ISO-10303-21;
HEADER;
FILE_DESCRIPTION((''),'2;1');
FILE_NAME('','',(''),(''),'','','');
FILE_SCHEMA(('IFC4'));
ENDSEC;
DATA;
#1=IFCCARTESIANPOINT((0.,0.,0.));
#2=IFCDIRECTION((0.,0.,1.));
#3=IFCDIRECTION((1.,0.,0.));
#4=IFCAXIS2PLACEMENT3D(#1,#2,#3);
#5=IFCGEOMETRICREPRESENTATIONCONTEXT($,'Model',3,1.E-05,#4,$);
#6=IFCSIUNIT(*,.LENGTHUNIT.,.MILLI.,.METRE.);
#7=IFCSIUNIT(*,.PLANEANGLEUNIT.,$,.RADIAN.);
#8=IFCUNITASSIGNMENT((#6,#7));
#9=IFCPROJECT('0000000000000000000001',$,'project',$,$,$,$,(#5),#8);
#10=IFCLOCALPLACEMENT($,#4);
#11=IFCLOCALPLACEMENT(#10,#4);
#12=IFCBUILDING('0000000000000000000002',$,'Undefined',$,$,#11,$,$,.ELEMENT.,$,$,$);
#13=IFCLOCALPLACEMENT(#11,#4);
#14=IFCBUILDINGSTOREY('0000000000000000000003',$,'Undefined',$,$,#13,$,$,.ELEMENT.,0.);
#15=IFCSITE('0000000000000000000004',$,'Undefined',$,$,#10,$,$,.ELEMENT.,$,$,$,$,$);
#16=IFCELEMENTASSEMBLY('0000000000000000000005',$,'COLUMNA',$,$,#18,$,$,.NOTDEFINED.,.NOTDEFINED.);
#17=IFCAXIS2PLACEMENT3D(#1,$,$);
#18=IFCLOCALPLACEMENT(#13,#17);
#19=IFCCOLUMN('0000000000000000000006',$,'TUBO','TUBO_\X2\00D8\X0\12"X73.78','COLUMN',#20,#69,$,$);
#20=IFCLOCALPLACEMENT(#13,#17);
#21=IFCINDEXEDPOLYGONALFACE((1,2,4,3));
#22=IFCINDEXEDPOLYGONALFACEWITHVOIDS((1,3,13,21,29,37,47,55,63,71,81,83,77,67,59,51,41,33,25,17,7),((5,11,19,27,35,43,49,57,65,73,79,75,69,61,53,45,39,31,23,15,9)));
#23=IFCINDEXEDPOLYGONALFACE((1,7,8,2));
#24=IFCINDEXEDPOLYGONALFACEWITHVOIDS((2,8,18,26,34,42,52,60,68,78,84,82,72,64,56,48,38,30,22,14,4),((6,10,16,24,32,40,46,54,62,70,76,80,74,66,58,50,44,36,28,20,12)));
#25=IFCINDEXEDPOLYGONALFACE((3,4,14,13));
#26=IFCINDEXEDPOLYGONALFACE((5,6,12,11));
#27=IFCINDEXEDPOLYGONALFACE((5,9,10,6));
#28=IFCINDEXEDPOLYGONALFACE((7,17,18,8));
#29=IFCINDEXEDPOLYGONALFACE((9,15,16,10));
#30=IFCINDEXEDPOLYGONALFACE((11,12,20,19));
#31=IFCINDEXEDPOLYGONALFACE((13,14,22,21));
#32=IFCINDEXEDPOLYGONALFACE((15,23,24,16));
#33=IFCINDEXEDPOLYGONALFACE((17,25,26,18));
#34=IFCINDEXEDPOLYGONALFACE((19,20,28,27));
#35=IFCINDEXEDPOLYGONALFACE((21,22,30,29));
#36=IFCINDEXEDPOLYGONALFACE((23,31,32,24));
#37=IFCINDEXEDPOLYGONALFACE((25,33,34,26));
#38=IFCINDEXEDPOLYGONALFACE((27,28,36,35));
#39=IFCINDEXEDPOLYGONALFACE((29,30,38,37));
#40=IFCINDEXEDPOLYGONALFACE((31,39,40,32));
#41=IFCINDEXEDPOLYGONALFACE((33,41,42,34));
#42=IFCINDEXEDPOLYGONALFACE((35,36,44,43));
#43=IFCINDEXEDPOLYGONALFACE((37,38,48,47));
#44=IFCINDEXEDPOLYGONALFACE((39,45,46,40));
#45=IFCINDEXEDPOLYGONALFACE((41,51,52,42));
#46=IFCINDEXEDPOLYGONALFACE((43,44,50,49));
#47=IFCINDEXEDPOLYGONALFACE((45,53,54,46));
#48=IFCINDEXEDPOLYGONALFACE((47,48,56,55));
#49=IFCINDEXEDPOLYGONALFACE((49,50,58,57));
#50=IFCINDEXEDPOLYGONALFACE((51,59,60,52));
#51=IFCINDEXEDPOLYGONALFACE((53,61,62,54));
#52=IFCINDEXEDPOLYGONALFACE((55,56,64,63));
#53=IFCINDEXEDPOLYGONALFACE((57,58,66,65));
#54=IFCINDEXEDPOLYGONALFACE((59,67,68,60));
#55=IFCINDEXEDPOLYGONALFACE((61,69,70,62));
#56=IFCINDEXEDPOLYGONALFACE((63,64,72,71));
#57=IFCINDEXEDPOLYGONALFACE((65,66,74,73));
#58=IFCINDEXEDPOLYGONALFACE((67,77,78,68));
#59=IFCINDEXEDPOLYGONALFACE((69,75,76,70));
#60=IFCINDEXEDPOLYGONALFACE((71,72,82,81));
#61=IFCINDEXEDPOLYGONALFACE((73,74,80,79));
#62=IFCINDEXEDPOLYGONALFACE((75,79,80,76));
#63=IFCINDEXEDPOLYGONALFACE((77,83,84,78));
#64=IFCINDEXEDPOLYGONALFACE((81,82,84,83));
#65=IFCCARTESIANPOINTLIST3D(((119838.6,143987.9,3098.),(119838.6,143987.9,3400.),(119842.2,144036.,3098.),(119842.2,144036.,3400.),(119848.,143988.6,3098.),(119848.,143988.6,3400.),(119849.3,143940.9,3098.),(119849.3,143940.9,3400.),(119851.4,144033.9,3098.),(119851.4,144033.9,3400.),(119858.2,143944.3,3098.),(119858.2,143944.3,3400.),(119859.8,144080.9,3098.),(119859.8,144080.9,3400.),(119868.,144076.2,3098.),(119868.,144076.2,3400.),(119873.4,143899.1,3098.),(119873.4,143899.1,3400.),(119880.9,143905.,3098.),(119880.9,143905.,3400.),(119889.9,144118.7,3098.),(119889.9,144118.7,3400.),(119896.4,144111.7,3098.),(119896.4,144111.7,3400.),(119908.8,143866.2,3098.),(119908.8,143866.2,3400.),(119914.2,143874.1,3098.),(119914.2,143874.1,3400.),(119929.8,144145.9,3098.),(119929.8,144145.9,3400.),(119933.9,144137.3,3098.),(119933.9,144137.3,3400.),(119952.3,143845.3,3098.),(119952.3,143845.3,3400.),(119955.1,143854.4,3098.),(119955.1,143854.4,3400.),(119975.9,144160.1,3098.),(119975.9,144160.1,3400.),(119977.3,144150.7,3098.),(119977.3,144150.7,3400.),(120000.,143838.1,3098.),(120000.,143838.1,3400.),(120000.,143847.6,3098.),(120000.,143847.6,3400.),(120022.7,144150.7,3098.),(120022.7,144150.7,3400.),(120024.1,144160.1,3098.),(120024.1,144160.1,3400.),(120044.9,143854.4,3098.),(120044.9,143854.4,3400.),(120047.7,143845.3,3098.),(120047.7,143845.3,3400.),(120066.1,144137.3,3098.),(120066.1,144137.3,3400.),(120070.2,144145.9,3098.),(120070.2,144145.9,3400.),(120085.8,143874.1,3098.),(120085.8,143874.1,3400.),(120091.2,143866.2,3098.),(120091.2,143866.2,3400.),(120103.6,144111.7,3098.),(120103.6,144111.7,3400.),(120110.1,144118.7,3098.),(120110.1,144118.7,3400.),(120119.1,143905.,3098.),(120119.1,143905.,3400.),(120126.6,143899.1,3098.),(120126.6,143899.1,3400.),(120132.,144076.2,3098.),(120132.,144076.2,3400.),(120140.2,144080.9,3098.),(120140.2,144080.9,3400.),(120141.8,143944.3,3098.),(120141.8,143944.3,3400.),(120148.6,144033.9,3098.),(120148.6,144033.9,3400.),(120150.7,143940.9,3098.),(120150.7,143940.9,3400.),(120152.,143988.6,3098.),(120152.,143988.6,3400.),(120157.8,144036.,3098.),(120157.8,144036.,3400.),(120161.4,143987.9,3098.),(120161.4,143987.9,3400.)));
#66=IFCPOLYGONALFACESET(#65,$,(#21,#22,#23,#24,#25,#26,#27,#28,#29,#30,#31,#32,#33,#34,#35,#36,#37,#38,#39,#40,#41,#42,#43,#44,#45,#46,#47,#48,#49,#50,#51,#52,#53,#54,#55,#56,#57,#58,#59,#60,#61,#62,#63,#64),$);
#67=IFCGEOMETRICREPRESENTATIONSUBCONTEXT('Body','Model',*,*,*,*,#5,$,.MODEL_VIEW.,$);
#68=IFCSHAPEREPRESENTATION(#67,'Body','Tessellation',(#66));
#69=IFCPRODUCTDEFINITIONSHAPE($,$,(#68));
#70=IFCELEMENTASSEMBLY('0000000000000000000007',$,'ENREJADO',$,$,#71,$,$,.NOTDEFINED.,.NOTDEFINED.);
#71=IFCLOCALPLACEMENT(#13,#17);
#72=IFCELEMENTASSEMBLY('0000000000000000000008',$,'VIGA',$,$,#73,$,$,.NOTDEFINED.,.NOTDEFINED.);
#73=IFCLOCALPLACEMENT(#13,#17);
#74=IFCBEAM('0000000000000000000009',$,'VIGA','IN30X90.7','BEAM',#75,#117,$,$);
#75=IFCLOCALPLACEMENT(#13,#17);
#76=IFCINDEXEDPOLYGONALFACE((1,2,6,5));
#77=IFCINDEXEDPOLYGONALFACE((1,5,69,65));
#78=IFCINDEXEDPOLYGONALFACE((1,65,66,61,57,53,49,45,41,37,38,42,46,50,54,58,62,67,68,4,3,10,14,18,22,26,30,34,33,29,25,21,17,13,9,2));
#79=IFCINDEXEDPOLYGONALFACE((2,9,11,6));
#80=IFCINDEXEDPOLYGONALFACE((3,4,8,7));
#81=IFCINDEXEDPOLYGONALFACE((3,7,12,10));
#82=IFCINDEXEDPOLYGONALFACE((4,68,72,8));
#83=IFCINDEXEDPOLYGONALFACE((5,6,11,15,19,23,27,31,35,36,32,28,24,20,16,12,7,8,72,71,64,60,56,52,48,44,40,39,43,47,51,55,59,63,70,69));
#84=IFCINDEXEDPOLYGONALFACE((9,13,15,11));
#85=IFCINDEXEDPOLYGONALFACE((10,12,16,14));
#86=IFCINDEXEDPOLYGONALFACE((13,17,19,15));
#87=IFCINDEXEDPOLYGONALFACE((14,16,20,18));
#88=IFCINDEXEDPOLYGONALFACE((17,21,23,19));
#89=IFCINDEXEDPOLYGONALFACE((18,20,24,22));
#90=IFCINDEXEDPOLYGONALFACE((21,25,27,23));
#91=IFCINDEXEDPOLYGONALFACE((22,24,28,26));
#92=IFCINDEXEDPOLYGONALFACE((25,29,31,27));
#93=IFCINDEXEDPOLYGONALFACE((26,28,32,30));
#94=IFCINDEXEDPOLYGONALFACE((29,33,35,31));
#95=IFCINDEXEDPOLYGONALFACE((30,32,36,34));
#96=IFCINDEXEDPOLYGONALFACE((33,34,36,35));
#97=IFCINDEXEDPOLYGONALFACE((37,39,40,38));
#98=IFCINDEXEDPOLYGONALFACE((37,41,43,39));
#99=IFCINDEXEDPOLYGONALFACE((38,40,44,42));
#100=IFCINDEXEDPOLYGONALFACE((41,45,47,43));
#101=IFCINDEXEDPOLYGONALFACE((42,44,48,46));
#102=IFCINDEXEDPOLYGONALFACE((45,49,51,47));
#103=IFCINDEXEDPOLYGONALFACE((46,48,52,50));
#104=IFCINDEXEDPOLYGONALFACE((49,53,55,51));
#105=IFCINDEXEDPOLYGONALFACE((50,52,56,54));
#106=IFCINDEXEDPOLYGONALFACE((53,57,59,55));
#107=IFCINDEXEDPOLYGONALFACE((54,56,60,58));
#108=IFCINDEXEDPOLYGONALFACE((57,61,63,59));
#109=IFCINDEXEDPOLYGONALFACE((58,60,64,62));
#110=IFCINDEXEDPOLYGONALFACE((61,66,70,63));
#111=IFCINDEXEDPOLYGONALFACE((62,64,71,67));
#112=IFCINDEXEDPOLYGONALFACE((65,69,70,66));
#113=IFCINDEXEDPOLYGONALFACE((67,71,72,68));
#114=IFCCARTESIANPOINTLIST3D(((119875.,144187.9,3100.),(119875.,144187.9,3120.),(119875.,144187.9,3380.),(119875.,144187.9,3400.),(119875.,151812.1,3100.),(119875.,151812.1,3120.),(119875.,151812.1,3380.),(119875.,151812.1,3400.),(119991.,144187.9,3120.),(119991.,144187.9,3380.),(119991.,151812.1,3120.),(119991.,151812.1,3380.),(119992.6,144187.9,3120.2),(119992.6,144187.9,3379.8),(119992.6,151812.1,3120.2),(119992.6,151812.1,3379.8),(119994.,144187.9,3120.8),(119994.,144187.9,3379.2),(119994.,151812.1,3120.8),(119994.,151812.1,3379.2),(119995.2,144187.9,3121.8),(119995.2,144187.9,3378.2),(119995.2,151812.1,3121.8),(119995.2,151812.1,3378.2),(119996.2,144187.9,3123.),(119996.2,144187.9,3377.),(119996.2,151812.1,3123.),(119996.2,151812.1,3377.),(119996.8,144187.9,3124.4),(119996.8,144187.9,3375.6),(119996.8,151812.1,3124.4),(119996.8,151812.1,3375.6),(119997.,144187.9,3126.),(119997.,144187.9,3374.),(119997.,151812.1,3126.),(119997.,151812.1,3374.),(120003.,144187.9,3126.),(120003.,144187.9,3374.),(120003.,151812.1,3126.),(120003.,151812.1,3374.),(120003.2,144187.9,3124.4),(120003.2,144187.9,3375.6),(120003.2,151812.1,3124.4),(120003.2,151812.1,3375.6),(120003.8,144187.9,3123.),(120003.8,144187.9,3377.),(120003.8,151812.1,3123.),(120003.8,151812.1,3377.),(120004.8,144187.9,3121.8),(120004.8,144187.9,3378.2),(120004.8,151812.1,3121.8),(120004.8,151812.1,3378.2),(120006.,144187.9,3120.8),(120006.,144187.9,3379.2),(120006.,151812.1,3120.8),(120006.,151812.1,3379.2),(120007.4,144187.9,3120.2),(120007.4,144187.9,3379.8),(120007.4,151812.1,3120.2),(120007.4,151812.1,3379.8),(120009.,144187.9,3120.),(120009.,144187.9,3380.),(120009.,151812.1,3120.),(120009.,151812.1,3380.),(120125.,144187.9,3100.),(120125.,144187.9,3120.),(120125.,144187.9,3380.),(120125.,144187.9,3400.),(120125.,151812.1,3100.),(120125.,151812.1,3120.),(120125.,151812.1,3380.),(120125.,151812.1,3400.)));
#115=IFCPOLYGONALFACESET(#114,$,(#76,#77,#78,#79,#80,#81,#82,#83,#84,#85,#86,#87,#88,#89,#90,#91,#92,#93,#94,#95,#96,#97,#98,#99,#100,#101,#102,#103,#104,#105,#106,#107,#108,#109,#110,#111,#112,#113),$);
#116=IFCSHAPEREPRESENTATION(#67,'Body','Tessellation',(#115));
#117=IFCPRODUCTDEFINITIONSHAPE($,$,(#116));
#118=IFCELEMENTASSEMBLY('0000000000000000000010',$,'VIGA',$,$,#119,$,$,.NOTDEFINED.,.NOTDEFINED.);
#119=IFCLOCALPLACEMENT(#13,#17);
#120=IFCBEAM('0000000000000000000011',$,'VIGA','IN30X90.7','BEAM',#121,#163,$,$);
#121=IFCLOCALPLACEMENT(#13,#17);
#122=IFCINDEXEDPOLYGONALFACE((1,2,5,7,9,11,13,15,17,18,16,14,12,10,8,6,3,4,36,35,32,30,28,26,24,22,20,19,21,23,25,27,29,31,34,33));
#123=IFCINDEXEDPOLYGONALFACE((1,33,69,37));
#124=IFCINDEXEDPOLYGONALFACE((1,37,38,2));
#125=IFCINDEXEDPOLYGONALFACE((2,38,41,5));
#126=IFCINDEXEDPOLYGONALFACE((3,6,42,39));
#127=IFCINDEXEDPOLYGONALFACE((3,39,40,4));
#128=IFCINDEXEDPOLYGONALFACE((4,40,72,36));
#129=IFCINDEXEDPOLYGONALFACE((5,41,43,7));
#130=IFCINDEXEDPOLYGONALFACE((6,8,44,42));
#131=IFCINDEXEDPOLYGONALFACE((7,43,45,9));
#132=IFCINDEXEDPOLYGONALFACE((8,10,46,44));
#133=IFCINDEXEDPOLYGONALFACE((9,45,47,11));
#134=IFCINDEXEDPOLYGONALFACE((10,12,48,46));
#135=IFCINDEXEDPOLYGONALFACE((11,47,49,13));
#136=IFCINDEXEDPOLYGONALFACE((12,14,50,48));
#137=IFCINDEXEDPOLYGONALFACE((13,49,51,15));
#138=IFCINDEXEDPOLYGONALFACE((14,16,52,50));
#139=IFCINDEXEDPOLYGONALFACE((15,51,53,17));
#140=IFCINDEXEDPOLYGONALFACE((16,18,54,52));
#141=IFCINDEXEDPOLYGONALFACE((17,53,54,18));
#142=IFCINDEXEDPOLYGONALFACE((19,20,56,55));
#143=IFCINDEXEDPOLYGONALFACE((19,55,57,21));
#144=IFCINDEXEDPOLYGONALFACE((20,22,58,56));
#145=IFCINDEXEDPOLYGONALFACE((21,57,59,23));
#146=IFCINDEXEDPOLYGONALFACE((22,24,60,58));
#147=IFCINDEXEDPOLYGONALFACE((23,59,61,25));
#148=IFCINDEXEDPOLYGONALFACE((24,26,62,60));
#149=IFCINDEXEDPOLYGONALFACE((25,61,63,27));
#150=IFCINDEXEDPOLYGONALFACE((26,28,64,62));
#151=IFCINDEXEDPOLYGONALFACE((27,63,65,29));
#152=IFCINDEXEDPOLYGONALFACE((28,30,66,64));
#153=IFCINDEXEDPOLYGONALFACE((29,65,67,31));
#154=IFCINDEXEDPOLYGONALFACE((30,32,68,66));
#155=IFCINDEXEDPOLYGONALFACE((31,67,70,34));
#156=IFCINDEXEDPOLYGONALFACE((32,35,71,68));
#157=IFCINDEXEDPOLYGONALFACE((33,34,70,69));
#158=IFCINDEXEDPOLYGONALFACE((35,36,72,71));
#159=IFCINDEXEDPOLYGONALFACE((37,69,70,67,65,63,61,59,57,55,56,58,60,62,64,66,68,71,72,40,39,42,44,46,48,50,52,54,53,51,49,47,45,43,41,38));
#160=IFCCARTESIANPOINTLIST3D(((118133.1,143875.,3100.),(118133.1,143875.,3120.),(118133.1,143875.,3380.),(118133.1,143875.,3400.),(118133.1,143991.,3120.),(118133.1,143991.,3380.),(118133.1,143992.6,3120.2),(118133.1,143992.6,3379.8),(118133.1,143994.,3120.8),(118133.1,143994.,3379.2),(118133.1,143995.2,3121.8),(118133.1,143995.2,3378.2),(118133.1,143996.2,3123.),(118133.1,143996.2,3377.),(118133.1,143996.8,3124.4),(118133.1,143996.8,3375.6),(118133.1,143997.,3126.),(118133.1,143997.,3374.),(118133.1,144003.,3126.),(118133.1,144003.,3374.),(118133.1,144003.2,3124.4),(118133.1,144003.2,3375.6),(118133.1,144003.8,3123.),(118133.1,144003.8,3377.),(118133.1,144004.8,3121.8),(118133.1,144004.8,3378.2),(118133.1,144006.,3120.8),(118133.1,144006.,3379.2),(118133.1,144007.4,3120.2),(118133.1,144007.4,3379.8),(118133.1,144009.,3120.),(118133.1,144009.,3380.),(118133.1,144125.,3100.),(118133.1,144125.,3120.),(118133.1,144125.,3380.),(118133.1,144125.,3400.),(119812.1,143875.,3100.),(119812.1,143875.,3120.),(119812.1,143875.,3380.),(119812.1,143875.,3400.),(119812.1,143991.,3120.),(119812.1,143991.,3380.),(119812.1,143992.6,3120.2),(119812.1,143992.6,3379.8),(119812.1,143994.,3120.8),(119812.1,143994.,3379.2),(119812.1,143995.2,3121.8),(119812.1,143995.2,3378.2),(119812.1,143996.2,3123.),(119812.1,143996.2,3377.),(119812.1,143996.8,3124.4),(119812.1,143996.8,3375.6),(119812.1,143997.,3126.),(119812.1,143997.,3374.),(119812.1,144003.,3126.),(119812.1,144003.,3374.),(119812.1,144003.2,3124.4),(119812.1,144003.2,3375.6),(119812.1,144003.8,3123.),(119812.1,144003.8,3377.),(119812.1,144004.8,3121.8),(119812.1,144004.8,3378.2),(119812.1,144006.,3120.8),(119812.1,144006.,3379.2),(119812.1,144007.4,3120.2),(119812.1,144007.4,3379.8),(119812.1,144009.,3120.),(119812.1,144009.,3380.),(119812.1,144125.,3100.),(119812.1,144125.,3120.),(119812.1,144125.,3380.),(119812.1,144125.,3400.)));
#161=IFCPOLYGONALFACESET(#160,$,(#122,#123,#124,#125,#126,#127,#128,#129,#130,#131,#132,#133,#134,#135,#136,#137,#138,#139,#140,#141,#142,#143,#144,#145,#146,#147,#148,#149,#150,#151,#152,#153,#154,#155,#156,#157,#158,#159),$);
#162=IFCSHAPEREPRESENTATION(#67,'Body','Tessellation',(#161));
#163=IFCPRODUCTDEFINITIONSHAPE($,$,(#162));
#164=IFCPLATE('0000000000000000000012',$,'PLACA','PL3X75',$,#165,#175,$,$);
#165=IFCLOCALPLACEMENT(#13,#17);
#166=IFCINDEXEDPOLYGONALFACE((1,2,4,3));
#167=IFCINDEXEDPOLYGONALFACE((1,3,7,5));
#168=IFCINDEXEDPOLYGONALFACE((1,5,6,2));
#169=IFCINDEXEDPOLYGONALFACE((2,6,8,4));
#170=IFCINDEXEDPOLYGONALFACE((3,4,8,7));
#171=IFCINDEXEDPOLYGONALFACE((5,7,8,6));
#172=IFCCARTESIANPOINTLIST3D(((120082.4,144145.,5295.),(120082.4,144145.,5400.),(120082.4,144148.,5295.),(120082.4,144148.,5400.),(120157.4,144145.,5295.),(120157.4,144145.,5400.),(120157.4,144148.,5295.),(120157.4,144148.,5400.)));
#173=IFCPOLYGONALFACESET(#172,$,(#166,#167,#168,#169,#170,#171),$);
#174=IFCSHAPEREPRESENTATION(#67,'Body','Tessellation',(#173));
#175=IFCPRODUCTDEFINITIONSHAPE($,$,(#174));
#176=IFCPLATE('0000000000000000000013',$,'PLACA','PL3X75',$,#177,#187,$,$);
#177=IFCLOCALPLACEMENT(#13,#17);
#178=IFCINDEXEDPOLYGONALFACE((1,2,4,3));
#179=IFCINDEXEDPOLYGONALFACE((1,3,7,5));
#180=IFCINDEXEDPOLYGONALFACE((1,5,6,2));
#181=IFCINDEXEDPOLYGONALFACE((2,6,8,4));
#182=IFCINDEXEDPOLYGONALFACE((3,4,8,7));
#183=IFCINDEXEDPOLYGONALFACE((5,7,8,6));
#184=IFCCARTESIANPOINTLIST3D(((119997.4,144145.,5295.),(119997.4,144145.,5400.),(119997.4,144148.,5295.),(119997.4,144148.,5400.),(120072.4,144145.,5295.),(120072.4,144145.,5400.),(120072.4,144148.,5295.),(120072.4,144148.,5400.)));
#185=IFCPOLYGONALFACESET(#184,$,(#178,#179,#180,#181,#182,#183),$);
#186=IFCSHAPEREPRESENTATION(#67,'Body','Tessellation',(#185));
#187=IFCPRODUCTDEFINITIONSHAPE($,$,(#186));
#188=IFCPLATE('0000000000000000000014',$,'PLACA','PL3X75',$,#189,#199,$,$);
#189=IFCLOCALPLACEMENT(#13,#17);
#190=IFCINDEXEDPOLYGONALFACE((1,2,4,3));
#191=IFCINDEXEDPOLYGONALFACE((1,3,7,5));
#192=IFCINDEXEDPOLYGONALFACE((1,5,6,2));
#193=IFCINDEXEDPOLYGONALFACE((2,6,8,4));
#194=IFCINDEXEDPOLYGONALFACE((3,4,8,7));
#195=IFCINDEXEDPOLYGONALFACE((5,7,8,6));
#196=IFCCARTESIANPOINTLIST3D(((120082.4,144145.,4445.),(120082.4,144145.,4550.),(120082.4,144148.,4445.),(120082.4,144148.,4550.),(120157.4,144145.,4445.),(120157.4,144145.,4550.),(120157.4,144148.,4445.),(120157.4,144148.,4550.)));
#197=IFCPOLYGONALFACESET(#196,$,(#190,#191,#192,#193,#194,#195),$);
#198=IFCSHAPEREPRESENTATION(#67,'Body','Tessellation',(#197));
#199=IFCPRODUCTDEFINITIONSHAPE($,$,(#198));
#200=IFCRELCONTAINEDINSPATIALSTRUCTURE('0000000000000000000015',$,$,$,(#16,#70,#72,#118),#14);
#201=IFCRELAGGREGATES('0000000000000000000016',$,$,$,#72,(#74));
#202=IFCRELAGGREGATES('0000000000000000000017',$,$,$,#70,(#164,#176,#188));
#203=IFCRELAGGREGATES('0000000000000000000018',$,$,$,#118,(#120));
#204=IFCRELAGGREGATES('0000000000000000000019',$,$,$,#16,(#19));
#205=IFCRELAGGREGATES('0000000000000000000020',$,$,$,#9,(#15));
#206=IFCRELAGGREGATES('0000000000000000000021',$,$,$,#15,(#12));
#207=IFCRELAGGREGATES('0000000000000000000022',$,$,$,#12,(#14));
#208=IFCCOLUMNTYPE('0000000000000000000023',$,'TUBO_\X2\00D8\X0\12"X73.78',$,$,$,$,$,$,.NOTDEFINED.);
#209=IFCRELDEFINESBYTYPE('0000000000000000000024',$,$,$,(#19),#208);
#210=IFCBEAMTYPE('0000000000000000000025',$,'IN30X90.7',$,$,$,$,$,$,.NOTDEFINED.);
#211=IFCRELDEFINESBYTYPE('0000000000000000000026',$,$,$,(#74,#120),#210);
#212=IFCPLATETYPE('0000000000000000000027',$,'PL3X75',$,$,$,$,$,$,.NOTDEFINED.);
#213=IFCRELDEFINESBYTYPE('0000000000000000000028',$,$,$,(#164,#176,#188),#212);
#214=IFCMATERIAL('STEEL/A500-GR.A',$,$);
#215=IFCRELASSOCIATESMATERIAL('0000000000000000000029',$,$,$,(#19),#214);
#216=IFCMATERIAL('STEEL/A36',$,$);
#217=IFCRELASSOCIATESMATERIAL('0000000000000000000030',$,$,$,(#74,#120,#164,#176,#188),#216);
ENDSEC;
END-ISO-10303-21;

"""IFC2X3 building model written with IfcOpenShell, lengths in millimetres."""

from ifc_helpers import new_model, si_unit, frame, origin_with_axes, origin_2d_with_axis, place, context, subcontext, project, spatial, polyline, hollow_circle, i_section, outline, extrude, material, type_object, element, aggregate, save


model = new_model("IFC2X3")

# Units and contexts
model_context = context("Model", 3, precision=1e-05, world=origin_with_axes())
body_context = subcontext(model_context, "Body", "Model", "MODEL_VIEW")
ifc_project = project(units=[si_unit("LENGTHUNIT", "METRE", prefix="MILLI"), si_unit("PLANEANGLEUNIT", "RADIAN")], contexts=[model_context])

# Site, building, storey
site_placement = place(None, origin_with_axes())
site = spatial("IfcSite", under=ifc_project, at=site_placement, Name="Undefined", CompositionType="ELEMENT")
building_placement = place(site_placement, origin_with_axes())
building = spatial("IfcBuilding", under=site, at=building_placement, Name="Undefined", CompositionType="ELEMENT")
storey_placement = place(building_placement, origin_with_axes())
storey = spatial("IfcBuildingStorey", under=building, at=storey_placement, Name="Undefined", CompositionType="ELEMENT", Elevation=0.0)

# Element assemblies, column
assembly_1_placement = place(storey_placement, origin_with_axes())
assembly_1 = element("IfcElementAssembly", 1, at=assembly_1_placement, inside=storey, Name="COLUMNA", AssemblyPlace="NOTDEFINED", PredefinedType="NOTDEFINED")
ifc_material_1 = material(Name="STEEL/A500-GR.A")
column_type_1 = type_object("IfcColumnType", Name="TUBO_Ø12\"X73.78", PredefinedType="NOTDEFINED")
column_1_placement = place(assembly_1_placement, frame((120000.0, 144000.0, 3098.0), z_axis=(0.0, 0.0, 1.0), x_axis=(-1.0, 0.0, 0.0)))
column_1 = element("IfcColumn", 2, at=column_1_placement, type_object=column_type_1, material=ifc_material_1, Name="TUBO", Description="TUBO_Ø12\"X73.78", ObjectType="COLUMN", context=body_context, shape_type="SweptSolid", body=[
    extrude(hollow_circle(Radius=161.9, WallThickness=9.5, at=origin_2d_with_axis()), frame((0.0, 0.0, 302.0), z_axis=(0.0, 0.0, -1.0), x_axis=(0.0, 1.0, 0.0)), (0.0, 0.0, 1.0), 302.0),
])
assembly_2_placement = place(storey_placement, origin_with_axes())
assembly_2 = element("IfcElementAssembly", 3, at=assembly_2_placement, inside=storey, Name="ENREJADO", AssemblyPlace="NOTDEFINED", PredefinedType="NOTDEFINED")
ifc_material_2 = material(Name="STEEL/A36")

# Element assemblies, beams
assembly_3_placement = place(storey_placement, origin_with_axes())
assembly_3 = element("IfcElementAssembly", 4, at=assembly_3_placement, inside=storey, Name="VIGA", AssemblyPlace="NOTDEFINED", PredefinedType="NOTDEFINED")
beam_type = type_object("IfcBeamType", Name="IN30X90.7", PredefinedType="NOTDEFINED")
beam_1_placement = place(assembly_3_placement, frame((120000.0, 144187.9, 3250.0), z_axis=(0.0, 0.0, 1.0), x_axis=(0.0, 1.0, 0.0)))
beam_1 = element("IfcBeam", 5, at=beam_1_placement, type_object=beam_type, material=ifc_material_2, Name="VIGA", Description="IN30X90.7", ObjectType="BEAM", context=body_context, shape_type="SweptSolid", body=[
    extrude(i_section(OverallWidth=250.0, OverallDepth=300.0, WebThickness=6.0, FlangeThickness=20.0, FilletRadius=6.0, at=origin_2d_with_axis()), frame((7624.2, 0.0, 0.0), z_axis=(-1.0, 0.0, 0.0), x_axis=(0.0, -1.0, 0.0)), (0.0, 0.0, 1.0), 7624.2),
])
aggregate(assembly_3, [beam_1])
assembly_4_placement = place(storey_placement, origin_with_axes())
assembly_4 = element("IfcElementAssembly", 6, at=assembly_4_placement, inside=storey, Name="VIGA", AssemblyPlace="NOTDEFINED", PredefinedType="NOTDEFINED")
beam_2_placement = place(assembly_4_placement, frame((118133.1, 144000.0, 3250.0), z_axis=(0.0, 0.0, 1.0), x_axis=(1.0, -0.000002, 0.0)))
beam_2 = element("IfcBeam", 7, at=beam_2_placement, type_object=beam_type, material=ifc_material_2, Name="VIGA", Description="IN30X90.7", ObjectType="BEAM", context=body_context, shape_type="SweptSolid", body=[
    extrude(i_section(OverallWidth=250.0, OverallDepth=300.0, WebThickness=6.0, FlangeThickness=20.0, FilletRadius=6.0, at=origin_2d_with_axis()), frame((1679.0, 0.0, 0.0), z_axis=(-1.0, 0.0, 0.0), x_axis=(0.0, -1.0, 0.0)), (0.0, 0.0, 1.0), 1679.0),
])

# Plates
plate_type_1 = type_object("IfcPlateType", Name="PL3X75", PredefinedType="NOTDEFINED")
plate_1_placement = place(assembly_2_placement, frame((120157.4, 144146.5, 5295.0), z_axis=(0.0, 1.0, 0.0), x_axis=(-1.0, 0.0, 0.0)))
plate_1 = element("IfcPlate", 8, at=plate_1_placement, type_object=plate_type_1, material=ifc_material_2, Name="PLACA", Description="PL3X75", context=body_context, shape_type="SweptSolid", body=[
    extrude(outline(polyline([(0.0, 0.0), (75.0, 0.0), (75.0, 105.0), (0.0, 105.0), (0.0, 0.0)])), frame((0.0, 0.0, -1.5), z_axis=(0.0, 0.0, 1.0), x_axis=(1.0, 0.0, 0.0)), (0.0, 0.0, 1.0), 3.0),
])
plate_2_placement = place(assembly_2_placement, frame((120072.4, 144146.5, 5295.0), z_axis=(0.0, 1.0, 0.0), x_axis=(-1.0, 0.0, 0.0)))
plate_2 = element("IfcPlate", 9, at=plate_2_placement, type_object=plate_type_1, material=ifc_material_2, Name="PLACA", Description="PL3X75", context=body_context, shape_type="SweptSolid", body=[
    extrude(outline(polyline([(0.0, 0.0), (75.0, 0.0), (75.0, 105.0), (0.0, 105.0), (0.0, 0.0)])), frame((0.0, 0.0, -1.5), z_axis=(0.0, 0.0, 1.0), x_axis=(1.0, 0.0, 0.0)), (0.0, 0.0, 1.0), 3.0),
])
plate_3_placement = place(assembly_2_placement, frame((120157.4, 144146.5, 4445.0), z_axis=(0.0, 1.0, 0.0), x_axis=(-1.0, 0.0, 0.0)))
plate_3 = element("IfcPlate", 10, at=plate_3_placement, type_object=plate_type_1, material=ifc_material_2, Name="PLACA", Description="PL3X75", context=body_context, shape_type="SweptSolid", body=[
    extrude(outline(polyline([(0.0, 0.0), (75.0, 0.0), (75.0, 105.0), (0.0, 105.0), (0.0, 0.0)])), frame((0.0, 0.0, -1.5), z_axis=(0.0, 0.0, 1.0), x_axis=(1.0, 0.0, 0.0)), (0.0, 0.0, 1.0), 3.0),
])
aggregate(assembly_2, [plate_1, plate_2, plate_3])

aggregate(assembly_4, [beam_2])

aggregate(assembly_1, [column_1])

save(model, "model.ifc")
